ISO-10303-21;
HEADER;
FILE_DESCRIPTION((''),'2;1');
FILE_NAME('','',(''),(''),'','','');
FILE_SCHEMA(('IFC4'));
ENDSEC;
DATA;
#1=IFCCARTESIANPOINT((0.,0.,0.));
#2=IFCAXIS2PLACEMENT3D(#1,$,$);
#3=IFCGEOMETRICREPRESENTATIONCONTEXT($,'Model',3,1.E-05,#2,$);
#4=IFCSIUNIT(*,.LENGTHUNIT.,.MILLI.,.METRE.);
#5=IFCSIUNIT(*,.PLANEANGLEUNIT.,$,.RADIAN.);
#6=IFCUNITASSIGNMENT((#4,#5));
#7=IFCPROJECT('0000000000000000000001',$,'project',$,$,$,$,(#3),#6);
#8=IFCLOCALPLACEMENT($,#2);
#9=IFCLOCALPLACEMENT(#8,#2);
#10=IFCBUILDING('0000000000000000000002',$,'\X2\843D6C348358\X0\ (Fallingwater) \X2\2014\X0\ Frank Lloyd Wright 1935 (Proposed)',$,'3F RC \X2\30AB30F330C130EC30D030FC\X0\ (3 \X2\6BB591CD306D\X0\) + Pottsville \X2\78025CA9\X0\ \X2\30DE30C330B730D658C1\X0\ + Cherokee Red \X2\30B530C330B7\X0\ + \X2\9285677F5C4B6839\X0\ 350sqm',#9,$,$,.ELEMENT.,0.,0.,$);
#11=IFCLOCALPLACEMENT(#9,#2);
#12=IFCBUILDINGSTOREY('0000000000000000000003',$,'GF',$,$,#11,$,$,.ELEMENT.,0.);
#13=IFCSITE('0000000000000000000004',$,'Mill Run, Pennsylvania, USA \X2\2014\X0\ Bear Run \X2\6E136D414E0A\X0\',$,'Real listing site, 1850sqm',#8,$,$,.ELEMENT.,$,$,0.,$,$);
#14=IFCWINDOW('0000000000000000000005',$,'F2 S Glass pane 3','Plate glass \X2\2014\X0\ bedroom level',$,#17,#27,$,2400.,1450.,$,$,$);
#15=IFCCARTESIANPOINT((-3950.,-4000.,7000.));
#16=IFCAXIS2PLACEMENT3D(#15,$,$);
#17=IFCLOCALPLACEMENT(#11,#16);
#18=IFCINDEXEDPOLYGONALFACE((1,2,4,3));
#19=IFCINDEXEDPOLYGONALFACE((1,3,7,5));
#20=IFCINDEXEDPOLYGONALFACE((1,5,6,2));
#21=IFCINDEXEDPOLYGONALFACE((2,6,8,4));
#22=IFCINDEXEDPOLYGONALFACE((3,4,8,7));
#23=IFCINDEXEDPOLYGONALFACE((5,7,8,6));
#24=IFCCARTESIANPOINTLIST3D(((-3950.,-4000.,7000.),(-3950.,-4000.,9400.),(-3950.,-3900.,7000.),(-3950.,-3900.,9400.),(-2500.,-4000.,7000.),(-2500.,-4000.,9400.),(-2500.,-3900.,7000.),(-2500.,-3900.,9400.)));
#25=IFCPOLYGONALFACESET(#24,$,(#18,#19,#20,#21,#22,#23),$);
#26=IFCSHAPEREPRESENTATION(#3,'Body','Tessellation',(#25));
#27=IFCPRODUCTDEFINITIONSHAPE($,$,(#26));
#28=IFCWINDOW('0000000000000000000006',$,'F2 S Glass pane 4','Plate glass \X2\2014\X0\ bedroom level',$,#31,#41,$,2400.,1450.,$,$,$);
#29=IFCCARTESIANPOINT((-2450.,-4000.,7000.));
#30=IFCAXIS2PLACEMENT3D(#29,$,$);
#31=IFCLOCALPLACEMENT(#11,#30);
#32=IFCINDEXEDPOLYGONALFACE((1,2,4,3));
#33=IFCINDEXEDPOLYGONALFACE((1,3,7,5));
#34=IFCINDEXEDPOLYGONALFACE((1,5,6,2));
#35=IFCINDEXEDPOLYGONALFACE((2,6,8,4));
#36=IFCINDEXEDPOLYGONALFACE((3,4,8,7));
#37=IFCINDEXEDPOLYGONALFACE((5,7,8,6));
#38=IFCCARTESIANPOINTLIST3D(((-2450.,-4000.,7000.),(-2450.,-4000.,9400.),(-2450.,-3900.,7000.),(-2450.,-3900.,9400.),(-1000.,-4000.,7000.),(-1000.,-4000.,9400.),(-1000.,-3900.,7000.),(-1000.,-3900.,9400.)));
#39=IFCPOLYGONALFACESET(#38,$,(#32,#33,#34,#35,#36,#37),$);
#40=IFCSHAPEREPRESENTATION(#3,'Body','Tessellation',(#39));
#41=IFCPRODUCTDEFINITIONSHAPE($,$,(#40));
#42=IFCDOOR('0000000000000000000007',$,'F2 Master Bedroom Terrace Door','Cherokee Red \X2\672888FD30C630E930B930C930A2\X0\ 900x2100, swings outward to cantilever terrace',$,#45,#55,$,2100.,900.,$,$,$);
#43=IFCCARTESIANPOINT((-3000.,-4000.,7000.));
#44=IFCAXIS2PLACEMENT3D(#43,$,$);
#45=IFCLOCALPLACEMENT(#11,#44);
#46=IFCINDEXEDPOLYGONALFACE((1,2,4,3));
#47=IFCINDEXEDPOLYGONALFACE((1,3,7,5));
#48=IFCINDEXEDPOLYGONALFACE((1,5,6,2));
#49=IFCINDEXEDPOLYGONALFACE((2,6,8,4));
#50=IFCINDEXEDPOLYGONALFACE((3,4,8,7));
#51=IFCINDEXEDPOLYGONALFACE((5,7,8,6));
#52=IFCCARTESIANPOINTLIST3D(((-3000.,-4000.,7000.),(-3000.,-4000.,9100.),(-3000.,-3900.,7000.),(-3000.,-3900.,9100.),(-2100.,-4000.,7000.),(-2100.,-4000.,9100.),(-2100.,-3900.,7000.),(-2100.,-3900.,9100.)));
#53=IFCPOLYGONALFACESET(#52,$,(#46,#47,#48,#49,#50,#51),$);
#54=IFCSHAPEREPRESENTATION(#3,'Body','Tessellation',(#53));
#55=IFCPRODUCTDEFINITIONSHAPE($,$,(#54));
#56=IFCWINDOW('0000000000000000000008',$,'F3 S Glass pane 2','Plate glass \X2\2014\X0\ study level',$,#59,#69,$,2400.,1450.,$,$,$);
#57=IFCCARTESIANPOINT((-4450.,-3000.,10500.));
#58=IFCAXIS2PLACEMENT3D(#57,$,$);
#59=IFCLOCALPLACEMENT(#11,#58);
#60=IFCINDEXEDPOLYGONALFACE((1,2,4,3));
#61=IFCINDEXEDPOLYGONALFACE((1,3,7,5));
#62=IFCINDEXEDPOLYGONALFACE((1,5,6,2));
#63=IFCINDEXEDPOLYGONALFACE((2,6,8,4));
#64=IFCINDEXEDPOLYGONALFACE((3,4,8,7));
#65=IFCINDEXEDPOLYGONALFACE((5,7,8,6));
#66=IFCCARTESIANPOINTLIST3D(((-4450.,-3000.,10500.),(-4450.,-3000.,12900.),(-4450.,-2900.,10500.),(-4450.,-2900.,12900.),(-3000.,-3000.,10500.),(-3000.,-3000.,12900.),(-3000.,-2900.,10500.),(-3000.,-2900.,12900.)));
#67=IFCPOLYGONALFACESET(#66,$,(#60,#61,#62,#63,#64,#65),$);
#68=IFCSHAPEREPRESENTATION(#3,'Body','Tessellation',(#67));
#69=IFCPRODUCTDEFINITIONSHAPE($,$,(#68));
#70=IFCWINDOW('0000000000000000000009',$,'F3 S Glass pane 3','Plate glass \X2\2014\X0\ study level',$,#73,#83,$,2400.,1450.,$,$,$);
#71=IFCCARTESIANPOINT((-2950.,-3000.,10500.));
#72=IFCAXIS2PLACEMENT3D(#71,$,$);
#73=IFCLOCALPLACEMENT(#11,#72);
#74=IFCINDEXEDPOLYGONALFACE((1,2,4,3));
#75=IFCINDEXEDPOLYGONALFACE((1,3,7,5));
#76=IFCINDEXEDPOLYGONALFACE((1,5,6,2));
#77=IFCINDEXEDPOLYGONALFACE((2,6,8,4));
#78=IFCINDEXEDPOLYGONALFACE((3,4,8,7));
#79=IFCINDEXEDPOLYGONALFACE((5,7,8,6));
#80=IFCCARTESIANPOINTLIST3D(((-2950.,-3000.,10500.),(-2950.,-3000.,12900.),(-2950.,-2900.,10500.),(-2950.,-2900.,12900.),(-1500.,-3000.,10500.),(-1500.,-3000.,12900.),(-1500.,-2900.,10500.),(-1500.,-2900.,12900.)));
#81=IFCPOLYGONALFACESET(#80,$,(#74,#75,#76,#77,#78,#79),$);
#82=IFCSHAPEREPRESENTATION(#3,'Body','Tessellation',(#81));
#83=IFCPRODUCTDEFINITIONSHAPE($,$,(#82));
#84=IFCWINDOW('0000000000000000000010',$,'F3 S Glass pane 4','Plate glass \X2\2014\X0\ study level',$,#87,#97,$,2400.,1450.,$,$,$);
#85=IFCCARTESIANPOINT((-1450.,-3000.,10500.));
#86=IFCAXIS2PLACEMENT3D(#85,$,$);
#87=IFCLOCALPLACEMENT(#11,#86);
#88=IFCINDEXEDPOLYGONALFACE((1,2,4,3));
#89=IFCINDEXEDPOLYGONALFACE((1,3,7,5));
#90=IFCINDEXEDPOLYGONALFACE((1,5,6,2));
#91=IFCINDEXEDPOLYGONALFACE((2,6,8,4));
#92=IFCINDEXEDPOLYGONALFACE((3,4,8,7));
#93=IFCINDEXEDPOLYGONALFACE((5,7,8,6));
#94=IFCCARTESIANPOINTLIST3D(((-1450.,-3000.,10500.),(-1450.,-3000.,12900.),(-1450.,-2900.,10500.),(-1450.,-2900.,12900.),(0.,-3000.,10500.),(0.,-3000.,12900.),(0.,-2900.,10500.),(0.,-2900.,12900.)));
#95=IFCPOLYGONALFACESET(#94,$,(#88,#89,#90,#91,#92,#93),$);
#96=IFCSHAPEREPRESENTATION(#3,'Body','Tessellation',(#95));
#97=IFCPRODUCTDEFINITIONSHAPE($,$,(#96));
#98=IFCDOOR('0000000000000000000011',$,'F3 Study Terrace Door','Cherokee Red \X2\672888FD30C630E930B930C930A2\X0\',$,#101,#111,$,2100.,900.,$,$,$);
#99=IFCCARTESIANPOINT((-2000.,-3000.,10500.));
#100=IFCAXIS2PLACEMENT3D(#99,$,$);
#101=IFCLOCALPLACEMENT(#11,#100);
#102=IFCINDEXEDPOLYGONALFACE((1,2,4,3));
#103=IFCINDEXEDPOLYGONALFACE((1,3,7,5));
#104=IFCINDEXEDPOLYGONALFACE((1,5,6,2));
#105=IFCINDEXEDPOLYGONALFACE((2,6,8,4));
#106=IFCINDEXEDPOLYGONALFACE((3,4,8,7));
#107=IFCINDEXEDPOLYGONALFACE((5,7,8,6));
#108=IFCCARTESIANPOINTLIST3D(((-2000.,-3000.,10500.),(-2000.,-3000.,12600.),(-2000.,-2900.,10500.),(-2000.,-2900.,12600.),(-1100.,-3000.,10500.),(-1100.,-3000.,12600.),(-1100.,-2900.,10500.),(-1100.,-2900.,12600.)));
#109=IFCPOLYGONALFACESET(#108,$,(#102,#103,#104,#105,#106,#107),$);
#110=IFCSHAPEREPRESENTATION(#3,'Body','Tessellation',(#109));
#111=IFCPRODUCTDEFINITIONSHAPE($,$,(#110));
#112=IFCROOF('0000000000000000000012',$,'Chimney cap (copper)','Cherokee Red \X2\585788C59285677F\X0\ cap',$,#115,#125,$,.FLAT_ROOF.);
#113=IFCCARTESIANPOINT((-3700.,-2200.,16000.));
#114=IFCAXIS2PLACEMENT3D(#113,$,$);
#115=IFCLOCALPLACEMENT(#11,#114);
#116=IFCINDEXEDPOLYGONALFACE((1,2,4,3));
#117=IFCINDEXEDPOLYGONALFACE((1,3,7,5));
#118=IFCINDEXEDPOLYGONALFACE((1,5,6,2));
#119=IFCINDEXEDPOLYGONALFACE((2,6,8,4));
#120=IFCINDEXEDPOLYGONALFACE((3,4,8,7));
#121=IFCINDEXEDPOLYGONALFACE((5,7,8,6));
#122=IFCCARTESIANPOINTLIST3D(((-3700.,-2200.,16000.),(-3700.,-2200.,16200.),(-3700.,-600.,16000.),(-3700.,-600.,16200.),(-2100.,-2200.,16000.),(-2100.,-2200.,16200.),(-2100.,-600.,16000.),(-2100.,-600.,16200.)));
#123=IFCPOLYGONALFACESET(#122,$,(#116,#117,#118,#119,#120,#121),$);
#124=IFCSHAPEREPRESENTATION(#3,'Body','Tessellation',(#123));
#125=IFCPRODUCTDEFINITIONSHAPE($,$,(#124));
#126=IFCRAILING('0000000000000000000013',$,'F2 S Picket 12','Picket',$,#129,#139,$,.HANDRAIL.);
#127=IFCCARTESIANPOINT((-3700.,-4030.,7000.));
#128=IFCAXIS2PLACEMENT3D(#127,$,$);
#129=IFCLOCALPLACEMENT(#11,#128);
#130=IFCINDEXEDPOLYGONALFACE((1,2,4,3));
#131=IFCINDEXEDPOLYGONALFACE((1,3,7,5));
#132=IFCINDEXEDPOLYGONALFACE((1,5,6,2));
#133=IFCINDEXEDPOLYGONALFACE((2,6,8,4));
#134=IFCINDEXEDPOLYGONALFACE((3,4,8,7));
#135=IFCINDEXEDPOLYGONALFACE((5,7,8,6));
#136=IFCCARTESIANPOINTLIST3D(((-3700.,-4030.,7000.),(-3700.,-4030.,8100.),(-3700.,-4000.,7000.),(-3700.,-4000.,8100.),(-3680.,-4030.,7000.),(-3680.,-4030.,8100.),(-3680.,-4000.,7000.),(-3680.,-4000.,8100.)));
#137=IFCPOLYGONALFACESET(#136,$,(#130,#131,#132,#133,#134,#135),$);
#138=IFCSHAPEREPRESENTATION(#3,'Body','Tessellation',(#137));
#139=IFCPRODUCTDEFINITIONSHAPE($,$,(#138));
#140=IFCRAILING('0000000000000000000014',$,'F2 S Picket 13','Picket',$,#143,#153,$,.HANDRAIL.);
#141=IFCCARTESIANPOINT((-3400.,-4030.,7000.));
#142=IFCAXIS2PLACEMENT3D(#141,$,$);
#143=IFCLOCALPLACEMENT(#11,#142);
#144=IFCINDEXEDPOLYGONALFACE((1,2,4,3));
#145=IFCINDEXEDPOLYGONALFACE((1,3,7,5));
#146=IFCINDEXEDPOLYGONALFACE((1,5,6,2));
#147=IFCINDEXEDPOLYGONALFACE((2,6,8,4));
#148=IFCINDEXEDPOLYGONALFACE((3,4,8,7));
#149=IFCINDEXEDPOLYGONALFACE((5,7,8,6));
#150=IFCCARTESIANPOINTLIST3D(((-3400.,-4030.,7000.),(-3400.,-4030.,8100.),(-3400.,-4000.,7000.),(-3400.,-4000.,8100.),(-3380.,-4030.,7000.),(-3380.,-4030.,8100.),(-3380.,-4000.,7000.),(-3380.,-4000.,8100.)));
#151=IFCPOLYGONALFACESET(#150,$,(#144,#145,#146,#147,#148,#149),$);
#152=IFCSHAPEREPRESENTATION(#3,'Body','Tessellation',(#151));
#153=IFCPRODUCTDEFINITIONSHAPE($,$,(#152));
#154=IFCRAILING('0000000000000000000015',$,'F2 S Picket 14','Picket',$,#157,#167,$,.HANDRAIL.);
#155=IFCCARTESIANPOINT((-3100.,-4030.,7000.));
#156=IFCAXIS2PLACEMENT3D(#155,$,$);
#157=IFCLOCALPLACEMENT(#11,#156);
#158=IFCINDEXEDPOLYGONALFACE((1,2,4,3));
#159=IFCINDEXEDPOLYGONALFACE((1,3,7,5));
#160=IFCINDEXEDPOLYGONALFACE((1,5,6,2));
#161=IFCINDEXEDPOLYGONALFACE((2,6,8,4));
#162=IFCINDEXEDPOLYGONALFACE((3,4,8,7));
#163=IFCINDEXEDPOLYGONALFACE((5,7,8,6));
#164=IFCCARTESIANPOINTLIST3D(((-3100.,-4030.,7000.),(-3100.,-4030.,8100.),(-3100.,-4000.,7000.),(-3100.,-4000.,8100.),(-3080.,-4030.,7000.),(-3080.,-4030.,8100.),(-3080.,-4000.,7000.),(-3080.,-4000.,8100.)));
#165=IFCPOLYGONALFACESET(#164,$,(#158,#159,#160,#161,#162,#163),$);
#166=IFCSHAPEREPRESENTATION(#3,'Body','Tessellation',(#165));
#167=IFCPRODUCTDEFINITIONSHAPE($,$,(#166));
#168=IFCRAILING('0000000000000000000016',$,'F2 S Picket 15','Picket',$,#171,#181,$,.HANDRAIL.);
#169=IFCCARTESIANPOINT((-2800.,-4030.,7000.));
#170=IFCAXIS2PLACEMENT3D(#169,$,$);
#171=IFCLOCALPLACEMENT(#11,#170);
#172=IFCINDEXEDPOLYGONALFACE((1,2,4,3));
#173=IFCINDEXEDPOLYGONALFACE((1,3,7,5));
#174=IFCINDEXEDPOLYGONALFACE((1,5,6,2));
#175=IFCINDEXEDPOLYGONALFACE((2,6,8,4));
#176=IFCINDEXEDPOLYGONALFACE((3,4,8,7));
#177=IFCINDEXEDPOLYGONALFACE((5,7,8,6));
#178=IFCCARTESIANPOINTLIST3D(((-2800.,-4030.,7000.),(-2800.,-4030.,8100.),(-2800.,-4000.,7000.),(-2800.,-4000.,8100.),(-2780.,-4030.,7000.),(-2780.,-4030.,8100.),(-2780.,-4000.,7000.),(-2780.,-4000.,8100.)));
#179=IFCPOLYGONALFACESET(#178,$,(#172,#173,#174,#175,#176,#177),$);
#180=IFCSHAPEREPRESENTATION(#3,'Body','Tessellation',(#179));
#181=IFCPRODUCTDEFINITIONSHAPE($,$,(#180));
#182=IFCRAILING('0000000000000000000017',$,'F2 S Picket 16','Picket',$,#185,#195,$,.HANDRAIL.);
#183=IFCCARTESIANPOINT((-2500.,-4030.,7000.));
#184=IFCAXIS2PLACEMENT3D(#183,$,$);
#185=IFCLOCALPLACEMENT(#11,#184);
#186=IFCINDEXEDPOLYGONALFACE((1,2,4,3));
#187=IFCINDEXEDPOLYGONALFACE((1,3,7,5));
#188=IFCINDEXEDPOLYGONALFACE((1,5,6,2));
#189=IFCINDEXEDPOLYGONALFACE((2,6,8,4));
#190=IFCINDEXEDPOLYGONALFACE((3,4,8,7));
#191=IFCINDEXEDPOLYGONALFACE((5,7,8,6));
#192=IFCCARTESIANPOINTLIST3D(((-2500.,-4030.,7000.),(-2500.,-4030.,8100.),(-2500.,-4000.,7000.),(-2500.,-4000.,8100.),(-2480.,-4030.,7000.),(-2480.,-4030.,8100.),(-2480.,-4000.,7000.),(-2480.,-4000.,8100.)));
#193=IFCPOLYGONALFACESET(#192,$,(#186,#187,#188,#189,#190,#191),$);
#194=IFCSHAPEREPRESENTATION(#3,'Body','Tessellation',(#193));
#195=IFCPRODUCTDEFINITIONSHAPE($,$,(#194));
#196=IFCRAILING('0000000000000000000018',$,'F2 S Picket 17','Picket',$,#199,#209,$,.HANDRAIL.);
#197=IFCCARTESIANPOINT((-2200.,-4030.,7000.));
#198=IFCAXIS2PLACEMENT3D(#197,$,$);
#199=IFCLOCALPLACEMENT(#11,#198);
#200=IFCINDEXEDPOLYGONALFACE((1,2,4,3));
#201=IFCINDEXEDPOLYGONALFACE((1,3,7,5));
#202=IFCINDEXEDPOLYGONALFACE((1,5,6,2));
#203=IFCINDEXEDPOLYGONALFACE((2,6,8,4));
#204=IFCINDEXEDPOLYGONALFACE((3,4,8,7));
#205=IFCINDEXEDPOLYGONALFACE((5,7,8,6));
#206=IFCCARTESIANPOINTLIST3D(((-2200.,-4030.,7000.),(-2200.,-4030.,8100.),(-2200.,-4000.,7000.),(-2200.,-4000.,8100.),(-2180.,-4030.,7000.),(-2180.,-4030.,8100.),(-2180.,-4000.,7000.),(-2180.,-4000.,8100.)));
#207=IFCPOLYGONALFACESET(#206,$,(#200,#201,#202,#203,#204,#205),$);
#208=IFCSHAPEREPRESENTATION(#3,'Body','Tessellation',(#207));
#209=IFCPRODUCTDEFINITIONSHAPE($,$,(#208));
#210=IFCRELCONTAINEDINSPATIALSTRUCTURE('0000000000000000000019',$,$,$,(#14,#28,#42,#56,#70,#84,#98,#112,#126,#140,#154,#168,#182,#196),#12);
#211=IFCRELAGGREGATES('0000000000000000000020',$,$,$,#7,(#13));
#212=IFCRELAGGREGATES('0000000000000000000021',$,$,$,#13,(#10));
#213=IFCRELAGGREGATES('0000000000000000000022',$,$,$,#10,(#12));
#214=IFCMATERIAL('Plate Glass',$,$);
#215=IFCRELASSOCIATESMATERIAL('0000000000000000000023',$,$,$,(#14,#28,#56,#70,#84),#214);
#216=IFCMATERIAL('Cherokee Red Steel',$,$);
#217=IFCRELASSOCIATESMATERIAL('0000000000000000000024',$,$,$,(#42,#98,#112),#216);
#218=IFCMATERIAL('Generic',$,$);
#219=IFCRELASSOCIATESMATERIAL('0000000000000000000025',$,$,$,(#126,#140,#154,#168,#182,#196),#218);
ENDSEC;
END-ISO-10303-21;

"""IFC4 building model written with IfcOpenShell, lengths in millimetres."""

from ifc_helpers import new_model, si_unit, frame, frame_2d, origin, place, context, project, spatial, rectangle, extrude, material, element, save


model = new_model("IFC4")

# Units and contexts
model_context = context("Model", 3, precision=1e-05, world=origin())
ifc_project = project(units=[si_unit("LENGTHUNIT", "METRE", prefix="MILLI"), si_unit("PLANEANGLEUNIT", "RADIAN")], contexts=[model_context])

# Site, building, storey
site_placement = place(None, origin())
site = spatial("IfcSite", under=ifc_project, at=site_placement, Name="Mill Run, Pennsylvania, USA — Bear Run 渓流上", ObjectType="Real listing site, 1850sqm", CompositionType="ELEMENT", RefElevation=0.0)
building_placement = place(site_placement, origin())
building = spatial("IfcBuilding", under=site, at=building_placement, Name="落水荘 (Fallingwater) — Frank Lloyd Wright 1935 (Proposed)", ObjectType="3F RC カンチレバー (3 段重ね) + Pottsville 砂岩 マッシブ壁 + Cherokee Red サッシ + 銅板屋根 350sqm", CompositionType="ELEMENT", ElevationOfRefHeight=0.0, ElevationOfTerrain=0.0)
storey_placement = place(building_placement, origin())
storey = spatial("IfcBuildingStorey", under=building, at=storey_placement, Name="GF", CompositionType="ELEMENT", Elevation=0.0)

# Windows
ifc_material_1 = material(Name="Plate Glass")
window_1_placement = place(storey_placement, frame((-3950.0, -4000.0, 7000.0)))
element("IfcWindow", 1, at=window_1_placement, inside=storey, material=ifc_material_1, Name="F2 S Glass pane 3", Description="Plate glass — bedroom level", OverallHeight=2400.0, OverallWidth=1450.0, context=model_context, shape_type="SweptSolid", body=[
    extrude(rectangle(XDim=1450.0, YDim=100.0, at=frame_2d((725.0, 50.0))), frame((-3950.0, -4000.0, 7000.0)), (0.0, 0.0, 1.0), 2400.0),
])
window_2_placement = place(storey_placement, frame((-2450.0, -4000.0, 7000.0)))
element("IfcWindow", 2, at=window_2_placement, inside=storey, material=ifc_material_1, Name="F2 S Glass pane 4", Description="Plate glass — bedroom level", OverallHeight=2400.0, OverallWidth=1450.0, context=model_context, shape_type="SweptSolid", body=[
    extrude(rectangle(XDim=1450.0, YDim=100.0, at=frame_2d((725.0, 50.0))), frame((-2450.0, -4000.0, 7000.0)), (0.0, 0.0, 1.0), 2400.0),
])

# Door
ifc_material_2 = material(Name="Cherokee Red Steel")
door_1_placement = place(storey_placement, frame((-3000.0, -4000.0, 7000.0)))
element("IfcDoor", 3, at=door_1_placement, inside=storey, material=ifc_material_2, Name="F2 Master Bedroom Terrace Door", Description="Cherokee Red 木製テラスドア 900x2100, swings outward to cantilever terrace", OverallHeight=2100.0, OverallWidth=900.0, context=model_context, shape_type="SweptSolid", body=[
    extrude(rectangle(XDim=900.0, YDim=100.0, at=frame_2d((450.0, 50.0))), frame((-3000.0, -4000.0, 7000.0)), (0.0, 0.0, 1.0), 2100.0),
])

# Windows
window_3_placement = place(storey_placement, frame((-4450.0, -3000.0, 10500.0)))
element("IfcWindow", 4, at=window_3_placement, inside=storey, material=ifc_material_1, Name="F3 S Glass pane 2", Description="Plate glass — study level", OverallHeight=2400.0, OverallWidth=1450.0, context=model_context, shape_type="SweptSolid", body=[
    extrude(rectangle(XDim=1450.0, YDim=100.0, at=frame_2d((725.0, 50.0))), frame((-4450.0, -3000.0, 10500.0)), (0.0, 0.0, 1.0), 2400.0),
])
window_4_placement = place(storey_placement, frame((-2950.0, -3000.0, 10500.0)))
element("IfcWindow", 5, at=window_4_placement, inside=storey, material=ifc_material_1, Name="F3 S Glass pane 3", Description="Plate glass — study level", OverallHeight=2400.0, OverallWidth=1450.0, context=model_context, shape_type="SweptSolid", body=[
    extrude(rectangle(XDim=1450.0, YDim=100.0, at=frame_2d((725.0, 50.0))), frame((-2950.0, -3000.0, 10500.0)), (0.0, 0.0, 1.0), 2400.0),
])
window_5_placement = place(storey_placement, frame((-1450.0, -3000.0, 10500.0)))
element("IfcWindow", 6, at=window_5_placement, inside=storey, material=ifc_material_1, Name="F3 S Glass pane 4", Description="Plate glass — study level", OverallHeight=2400.0, OverallWidth=1450.0, context=model_context, shape_type="SweptSolid", body=[
    extrude(rectangle(XDim=1450.0, YDim=100.0, at=frame_2d((725.0, 50.0))), frame((-1450.0, -3000.0, 10500.0)), (0.0, 0.0, 1.0), 2400.0),
])

# Door
door_2_placement = place(storey_placement, frame((-2000.0, -3000.0, 10500.0)))
element("IfcDoor", 7, at=door_2_placement, inside=storey, material=ifc_material_2, Name="F3 Study Terrace Door", Description="Cherokee Red 木製テラスドア", OverallHeight=2100.0, OverallWidth=900.0, context=model_context, shape_type="SweptSolid", body=[
    extrude(rectangle(XDim=900.0, YDim=100.0, at=frame_2d((450.0, 50.0))), frame((-2000.0, -3000.0, 10500.0)), (0.0, 0.0, 1.0), 2100.0),
])

# Roof
roof_placement = place(storey_placement, frame((-3700.0, -2200.0, 16000.0)))
element("IfcRoof", 8, at=roof_placement, inside=storey, material=ifc_material_2, Name="Chimney cap (copper)", Description="Cherokee Red 塗装銅板 cap", PredefinedType="FLAT_ROOF", context=model_context, shape_type="SweptSolid", body=[
    extrude(rectangle(XDim=1600.0, YDim=1600.0, at=frame_2d((800.0, 800.0))), frame((-3700.0, -2200.0, 16000.0)), (0.0, 0.0, 1.0), 200.0),
])

# Railings
ifc_material_3 = material(Name="Generic")
railing_1_placement = place(storey_placement, frame((-3700.0, -4030.0, 7000.0)))
element("IfcRailing", 9, at=railing_1_placement, inside=storey, material=ifc_material_3, Name="F2 S Picket 12", Description="Picket", PredefinedType="HANDRAIL", context=model_context, shape_type="SweptSolid", body=[
    extrude(rectangle(XDim=20.0, YDim=30.0, at=frame_2d((10.0, 15.0))), frame((-3700.0, -4030.0, 7000.0)), (0.0, 0.0, 1.0), 1100.0),
])
railing_2_placement = place(storey_placement, frame((-3400.0, -4030.0, 7000.0)))
element("IfcRailing", 10, at=railing_2_placement, inside=storey, material=ifc_material_3, Name="F2 S Picket 13", Description="Picket", PredefinedType="HANDRAIL", context=model_context, shape_type="SweptSolid", body=[
    extrude(rectangle(XDim=20.0, YDim=30.0, at=frame_2d((10.0, 15.0))), frame((-3400.0, -4030.0, 7000.0)), (0.0, 0.0, 1.0), 1100.0),
])
railing_3_placement = place(storey_placement, frame((-3100.0, -4030.0, 7000.0)))
element("IfcRailing", 11, at=railing_3_placement, inside=storey, material=ifc_material_3, Name="F2 S Picket 14", Description="Picket", PredefinedType="HANDRAIL", context=model_context, shape_type="SweptSolid", body=[
    extrude(rectangle(XDim=20.0, YDim=30.0, at=frame_2d((10.0, 15.0))), frame((-3100.0, -4030.0, 7000.0)), (0.0, 0.0, 1.0), 1100.0),
])
railing_4_placement = place(storey_placement, frame((-2800.0, -4030.0, 7000.0)))
element("IfcRailing", 12, at=railing_4_placement, inside=storey, material=ifc_material_3, Name="F2 S Picket 15", Description="Picket", PredefinedType="HANDRAIL", context=model_context, shape_type="SweptSolid", body=[
    extrude(rectangle(XDim=20.0, YDim=30.0, at=frame_2d((10.0, 15.0))), frame((-2800.0, -4030.0, 7000.0)), (0.0, 0.0, 1.0), 1100.0),
])
railing_5_placement = place(storey_placement, frame((-2500.0, -4030.0, 7000.0)))
element("IfcRailing", 13, at=railing_5_placement, inside=storey, material=ifc_material_3, Name="F2 S Picket 16", Description="Picket", PredefinedType="HANDRAIL", context=model_context, shape_type="SweptSolid", body=[
    extrude(rectangle(XDim=20.0, YDim=30.0, at=frame_2d((10.0, 15.0))), frame((-2500.0, -4030.0, 7000.0)), (0.0, 0.0, 1.0), 1100.0),
])
railing_6_placement = place(storey_placement, frame((-2200.0, -4030.0, 7000.0)))
element("IfcRailing", 14, at=railing_6_placement, inside=storey, material=ifc_material_3, Name="F2 S Picket 17", Description="Picket", PredefinedType="HANDRAIL", context=model_context, shape_type="SweptSolid", body=[
    extrude(rectangle(XDim=20.0, YDim=30.0, at=frame_2d((10.0, 15.0))), frame((-2200.0, -4030.0, 7000.0)), (0.0, 0.0, 1.0), 1100.0),
])

save(model, "model.ifc")
